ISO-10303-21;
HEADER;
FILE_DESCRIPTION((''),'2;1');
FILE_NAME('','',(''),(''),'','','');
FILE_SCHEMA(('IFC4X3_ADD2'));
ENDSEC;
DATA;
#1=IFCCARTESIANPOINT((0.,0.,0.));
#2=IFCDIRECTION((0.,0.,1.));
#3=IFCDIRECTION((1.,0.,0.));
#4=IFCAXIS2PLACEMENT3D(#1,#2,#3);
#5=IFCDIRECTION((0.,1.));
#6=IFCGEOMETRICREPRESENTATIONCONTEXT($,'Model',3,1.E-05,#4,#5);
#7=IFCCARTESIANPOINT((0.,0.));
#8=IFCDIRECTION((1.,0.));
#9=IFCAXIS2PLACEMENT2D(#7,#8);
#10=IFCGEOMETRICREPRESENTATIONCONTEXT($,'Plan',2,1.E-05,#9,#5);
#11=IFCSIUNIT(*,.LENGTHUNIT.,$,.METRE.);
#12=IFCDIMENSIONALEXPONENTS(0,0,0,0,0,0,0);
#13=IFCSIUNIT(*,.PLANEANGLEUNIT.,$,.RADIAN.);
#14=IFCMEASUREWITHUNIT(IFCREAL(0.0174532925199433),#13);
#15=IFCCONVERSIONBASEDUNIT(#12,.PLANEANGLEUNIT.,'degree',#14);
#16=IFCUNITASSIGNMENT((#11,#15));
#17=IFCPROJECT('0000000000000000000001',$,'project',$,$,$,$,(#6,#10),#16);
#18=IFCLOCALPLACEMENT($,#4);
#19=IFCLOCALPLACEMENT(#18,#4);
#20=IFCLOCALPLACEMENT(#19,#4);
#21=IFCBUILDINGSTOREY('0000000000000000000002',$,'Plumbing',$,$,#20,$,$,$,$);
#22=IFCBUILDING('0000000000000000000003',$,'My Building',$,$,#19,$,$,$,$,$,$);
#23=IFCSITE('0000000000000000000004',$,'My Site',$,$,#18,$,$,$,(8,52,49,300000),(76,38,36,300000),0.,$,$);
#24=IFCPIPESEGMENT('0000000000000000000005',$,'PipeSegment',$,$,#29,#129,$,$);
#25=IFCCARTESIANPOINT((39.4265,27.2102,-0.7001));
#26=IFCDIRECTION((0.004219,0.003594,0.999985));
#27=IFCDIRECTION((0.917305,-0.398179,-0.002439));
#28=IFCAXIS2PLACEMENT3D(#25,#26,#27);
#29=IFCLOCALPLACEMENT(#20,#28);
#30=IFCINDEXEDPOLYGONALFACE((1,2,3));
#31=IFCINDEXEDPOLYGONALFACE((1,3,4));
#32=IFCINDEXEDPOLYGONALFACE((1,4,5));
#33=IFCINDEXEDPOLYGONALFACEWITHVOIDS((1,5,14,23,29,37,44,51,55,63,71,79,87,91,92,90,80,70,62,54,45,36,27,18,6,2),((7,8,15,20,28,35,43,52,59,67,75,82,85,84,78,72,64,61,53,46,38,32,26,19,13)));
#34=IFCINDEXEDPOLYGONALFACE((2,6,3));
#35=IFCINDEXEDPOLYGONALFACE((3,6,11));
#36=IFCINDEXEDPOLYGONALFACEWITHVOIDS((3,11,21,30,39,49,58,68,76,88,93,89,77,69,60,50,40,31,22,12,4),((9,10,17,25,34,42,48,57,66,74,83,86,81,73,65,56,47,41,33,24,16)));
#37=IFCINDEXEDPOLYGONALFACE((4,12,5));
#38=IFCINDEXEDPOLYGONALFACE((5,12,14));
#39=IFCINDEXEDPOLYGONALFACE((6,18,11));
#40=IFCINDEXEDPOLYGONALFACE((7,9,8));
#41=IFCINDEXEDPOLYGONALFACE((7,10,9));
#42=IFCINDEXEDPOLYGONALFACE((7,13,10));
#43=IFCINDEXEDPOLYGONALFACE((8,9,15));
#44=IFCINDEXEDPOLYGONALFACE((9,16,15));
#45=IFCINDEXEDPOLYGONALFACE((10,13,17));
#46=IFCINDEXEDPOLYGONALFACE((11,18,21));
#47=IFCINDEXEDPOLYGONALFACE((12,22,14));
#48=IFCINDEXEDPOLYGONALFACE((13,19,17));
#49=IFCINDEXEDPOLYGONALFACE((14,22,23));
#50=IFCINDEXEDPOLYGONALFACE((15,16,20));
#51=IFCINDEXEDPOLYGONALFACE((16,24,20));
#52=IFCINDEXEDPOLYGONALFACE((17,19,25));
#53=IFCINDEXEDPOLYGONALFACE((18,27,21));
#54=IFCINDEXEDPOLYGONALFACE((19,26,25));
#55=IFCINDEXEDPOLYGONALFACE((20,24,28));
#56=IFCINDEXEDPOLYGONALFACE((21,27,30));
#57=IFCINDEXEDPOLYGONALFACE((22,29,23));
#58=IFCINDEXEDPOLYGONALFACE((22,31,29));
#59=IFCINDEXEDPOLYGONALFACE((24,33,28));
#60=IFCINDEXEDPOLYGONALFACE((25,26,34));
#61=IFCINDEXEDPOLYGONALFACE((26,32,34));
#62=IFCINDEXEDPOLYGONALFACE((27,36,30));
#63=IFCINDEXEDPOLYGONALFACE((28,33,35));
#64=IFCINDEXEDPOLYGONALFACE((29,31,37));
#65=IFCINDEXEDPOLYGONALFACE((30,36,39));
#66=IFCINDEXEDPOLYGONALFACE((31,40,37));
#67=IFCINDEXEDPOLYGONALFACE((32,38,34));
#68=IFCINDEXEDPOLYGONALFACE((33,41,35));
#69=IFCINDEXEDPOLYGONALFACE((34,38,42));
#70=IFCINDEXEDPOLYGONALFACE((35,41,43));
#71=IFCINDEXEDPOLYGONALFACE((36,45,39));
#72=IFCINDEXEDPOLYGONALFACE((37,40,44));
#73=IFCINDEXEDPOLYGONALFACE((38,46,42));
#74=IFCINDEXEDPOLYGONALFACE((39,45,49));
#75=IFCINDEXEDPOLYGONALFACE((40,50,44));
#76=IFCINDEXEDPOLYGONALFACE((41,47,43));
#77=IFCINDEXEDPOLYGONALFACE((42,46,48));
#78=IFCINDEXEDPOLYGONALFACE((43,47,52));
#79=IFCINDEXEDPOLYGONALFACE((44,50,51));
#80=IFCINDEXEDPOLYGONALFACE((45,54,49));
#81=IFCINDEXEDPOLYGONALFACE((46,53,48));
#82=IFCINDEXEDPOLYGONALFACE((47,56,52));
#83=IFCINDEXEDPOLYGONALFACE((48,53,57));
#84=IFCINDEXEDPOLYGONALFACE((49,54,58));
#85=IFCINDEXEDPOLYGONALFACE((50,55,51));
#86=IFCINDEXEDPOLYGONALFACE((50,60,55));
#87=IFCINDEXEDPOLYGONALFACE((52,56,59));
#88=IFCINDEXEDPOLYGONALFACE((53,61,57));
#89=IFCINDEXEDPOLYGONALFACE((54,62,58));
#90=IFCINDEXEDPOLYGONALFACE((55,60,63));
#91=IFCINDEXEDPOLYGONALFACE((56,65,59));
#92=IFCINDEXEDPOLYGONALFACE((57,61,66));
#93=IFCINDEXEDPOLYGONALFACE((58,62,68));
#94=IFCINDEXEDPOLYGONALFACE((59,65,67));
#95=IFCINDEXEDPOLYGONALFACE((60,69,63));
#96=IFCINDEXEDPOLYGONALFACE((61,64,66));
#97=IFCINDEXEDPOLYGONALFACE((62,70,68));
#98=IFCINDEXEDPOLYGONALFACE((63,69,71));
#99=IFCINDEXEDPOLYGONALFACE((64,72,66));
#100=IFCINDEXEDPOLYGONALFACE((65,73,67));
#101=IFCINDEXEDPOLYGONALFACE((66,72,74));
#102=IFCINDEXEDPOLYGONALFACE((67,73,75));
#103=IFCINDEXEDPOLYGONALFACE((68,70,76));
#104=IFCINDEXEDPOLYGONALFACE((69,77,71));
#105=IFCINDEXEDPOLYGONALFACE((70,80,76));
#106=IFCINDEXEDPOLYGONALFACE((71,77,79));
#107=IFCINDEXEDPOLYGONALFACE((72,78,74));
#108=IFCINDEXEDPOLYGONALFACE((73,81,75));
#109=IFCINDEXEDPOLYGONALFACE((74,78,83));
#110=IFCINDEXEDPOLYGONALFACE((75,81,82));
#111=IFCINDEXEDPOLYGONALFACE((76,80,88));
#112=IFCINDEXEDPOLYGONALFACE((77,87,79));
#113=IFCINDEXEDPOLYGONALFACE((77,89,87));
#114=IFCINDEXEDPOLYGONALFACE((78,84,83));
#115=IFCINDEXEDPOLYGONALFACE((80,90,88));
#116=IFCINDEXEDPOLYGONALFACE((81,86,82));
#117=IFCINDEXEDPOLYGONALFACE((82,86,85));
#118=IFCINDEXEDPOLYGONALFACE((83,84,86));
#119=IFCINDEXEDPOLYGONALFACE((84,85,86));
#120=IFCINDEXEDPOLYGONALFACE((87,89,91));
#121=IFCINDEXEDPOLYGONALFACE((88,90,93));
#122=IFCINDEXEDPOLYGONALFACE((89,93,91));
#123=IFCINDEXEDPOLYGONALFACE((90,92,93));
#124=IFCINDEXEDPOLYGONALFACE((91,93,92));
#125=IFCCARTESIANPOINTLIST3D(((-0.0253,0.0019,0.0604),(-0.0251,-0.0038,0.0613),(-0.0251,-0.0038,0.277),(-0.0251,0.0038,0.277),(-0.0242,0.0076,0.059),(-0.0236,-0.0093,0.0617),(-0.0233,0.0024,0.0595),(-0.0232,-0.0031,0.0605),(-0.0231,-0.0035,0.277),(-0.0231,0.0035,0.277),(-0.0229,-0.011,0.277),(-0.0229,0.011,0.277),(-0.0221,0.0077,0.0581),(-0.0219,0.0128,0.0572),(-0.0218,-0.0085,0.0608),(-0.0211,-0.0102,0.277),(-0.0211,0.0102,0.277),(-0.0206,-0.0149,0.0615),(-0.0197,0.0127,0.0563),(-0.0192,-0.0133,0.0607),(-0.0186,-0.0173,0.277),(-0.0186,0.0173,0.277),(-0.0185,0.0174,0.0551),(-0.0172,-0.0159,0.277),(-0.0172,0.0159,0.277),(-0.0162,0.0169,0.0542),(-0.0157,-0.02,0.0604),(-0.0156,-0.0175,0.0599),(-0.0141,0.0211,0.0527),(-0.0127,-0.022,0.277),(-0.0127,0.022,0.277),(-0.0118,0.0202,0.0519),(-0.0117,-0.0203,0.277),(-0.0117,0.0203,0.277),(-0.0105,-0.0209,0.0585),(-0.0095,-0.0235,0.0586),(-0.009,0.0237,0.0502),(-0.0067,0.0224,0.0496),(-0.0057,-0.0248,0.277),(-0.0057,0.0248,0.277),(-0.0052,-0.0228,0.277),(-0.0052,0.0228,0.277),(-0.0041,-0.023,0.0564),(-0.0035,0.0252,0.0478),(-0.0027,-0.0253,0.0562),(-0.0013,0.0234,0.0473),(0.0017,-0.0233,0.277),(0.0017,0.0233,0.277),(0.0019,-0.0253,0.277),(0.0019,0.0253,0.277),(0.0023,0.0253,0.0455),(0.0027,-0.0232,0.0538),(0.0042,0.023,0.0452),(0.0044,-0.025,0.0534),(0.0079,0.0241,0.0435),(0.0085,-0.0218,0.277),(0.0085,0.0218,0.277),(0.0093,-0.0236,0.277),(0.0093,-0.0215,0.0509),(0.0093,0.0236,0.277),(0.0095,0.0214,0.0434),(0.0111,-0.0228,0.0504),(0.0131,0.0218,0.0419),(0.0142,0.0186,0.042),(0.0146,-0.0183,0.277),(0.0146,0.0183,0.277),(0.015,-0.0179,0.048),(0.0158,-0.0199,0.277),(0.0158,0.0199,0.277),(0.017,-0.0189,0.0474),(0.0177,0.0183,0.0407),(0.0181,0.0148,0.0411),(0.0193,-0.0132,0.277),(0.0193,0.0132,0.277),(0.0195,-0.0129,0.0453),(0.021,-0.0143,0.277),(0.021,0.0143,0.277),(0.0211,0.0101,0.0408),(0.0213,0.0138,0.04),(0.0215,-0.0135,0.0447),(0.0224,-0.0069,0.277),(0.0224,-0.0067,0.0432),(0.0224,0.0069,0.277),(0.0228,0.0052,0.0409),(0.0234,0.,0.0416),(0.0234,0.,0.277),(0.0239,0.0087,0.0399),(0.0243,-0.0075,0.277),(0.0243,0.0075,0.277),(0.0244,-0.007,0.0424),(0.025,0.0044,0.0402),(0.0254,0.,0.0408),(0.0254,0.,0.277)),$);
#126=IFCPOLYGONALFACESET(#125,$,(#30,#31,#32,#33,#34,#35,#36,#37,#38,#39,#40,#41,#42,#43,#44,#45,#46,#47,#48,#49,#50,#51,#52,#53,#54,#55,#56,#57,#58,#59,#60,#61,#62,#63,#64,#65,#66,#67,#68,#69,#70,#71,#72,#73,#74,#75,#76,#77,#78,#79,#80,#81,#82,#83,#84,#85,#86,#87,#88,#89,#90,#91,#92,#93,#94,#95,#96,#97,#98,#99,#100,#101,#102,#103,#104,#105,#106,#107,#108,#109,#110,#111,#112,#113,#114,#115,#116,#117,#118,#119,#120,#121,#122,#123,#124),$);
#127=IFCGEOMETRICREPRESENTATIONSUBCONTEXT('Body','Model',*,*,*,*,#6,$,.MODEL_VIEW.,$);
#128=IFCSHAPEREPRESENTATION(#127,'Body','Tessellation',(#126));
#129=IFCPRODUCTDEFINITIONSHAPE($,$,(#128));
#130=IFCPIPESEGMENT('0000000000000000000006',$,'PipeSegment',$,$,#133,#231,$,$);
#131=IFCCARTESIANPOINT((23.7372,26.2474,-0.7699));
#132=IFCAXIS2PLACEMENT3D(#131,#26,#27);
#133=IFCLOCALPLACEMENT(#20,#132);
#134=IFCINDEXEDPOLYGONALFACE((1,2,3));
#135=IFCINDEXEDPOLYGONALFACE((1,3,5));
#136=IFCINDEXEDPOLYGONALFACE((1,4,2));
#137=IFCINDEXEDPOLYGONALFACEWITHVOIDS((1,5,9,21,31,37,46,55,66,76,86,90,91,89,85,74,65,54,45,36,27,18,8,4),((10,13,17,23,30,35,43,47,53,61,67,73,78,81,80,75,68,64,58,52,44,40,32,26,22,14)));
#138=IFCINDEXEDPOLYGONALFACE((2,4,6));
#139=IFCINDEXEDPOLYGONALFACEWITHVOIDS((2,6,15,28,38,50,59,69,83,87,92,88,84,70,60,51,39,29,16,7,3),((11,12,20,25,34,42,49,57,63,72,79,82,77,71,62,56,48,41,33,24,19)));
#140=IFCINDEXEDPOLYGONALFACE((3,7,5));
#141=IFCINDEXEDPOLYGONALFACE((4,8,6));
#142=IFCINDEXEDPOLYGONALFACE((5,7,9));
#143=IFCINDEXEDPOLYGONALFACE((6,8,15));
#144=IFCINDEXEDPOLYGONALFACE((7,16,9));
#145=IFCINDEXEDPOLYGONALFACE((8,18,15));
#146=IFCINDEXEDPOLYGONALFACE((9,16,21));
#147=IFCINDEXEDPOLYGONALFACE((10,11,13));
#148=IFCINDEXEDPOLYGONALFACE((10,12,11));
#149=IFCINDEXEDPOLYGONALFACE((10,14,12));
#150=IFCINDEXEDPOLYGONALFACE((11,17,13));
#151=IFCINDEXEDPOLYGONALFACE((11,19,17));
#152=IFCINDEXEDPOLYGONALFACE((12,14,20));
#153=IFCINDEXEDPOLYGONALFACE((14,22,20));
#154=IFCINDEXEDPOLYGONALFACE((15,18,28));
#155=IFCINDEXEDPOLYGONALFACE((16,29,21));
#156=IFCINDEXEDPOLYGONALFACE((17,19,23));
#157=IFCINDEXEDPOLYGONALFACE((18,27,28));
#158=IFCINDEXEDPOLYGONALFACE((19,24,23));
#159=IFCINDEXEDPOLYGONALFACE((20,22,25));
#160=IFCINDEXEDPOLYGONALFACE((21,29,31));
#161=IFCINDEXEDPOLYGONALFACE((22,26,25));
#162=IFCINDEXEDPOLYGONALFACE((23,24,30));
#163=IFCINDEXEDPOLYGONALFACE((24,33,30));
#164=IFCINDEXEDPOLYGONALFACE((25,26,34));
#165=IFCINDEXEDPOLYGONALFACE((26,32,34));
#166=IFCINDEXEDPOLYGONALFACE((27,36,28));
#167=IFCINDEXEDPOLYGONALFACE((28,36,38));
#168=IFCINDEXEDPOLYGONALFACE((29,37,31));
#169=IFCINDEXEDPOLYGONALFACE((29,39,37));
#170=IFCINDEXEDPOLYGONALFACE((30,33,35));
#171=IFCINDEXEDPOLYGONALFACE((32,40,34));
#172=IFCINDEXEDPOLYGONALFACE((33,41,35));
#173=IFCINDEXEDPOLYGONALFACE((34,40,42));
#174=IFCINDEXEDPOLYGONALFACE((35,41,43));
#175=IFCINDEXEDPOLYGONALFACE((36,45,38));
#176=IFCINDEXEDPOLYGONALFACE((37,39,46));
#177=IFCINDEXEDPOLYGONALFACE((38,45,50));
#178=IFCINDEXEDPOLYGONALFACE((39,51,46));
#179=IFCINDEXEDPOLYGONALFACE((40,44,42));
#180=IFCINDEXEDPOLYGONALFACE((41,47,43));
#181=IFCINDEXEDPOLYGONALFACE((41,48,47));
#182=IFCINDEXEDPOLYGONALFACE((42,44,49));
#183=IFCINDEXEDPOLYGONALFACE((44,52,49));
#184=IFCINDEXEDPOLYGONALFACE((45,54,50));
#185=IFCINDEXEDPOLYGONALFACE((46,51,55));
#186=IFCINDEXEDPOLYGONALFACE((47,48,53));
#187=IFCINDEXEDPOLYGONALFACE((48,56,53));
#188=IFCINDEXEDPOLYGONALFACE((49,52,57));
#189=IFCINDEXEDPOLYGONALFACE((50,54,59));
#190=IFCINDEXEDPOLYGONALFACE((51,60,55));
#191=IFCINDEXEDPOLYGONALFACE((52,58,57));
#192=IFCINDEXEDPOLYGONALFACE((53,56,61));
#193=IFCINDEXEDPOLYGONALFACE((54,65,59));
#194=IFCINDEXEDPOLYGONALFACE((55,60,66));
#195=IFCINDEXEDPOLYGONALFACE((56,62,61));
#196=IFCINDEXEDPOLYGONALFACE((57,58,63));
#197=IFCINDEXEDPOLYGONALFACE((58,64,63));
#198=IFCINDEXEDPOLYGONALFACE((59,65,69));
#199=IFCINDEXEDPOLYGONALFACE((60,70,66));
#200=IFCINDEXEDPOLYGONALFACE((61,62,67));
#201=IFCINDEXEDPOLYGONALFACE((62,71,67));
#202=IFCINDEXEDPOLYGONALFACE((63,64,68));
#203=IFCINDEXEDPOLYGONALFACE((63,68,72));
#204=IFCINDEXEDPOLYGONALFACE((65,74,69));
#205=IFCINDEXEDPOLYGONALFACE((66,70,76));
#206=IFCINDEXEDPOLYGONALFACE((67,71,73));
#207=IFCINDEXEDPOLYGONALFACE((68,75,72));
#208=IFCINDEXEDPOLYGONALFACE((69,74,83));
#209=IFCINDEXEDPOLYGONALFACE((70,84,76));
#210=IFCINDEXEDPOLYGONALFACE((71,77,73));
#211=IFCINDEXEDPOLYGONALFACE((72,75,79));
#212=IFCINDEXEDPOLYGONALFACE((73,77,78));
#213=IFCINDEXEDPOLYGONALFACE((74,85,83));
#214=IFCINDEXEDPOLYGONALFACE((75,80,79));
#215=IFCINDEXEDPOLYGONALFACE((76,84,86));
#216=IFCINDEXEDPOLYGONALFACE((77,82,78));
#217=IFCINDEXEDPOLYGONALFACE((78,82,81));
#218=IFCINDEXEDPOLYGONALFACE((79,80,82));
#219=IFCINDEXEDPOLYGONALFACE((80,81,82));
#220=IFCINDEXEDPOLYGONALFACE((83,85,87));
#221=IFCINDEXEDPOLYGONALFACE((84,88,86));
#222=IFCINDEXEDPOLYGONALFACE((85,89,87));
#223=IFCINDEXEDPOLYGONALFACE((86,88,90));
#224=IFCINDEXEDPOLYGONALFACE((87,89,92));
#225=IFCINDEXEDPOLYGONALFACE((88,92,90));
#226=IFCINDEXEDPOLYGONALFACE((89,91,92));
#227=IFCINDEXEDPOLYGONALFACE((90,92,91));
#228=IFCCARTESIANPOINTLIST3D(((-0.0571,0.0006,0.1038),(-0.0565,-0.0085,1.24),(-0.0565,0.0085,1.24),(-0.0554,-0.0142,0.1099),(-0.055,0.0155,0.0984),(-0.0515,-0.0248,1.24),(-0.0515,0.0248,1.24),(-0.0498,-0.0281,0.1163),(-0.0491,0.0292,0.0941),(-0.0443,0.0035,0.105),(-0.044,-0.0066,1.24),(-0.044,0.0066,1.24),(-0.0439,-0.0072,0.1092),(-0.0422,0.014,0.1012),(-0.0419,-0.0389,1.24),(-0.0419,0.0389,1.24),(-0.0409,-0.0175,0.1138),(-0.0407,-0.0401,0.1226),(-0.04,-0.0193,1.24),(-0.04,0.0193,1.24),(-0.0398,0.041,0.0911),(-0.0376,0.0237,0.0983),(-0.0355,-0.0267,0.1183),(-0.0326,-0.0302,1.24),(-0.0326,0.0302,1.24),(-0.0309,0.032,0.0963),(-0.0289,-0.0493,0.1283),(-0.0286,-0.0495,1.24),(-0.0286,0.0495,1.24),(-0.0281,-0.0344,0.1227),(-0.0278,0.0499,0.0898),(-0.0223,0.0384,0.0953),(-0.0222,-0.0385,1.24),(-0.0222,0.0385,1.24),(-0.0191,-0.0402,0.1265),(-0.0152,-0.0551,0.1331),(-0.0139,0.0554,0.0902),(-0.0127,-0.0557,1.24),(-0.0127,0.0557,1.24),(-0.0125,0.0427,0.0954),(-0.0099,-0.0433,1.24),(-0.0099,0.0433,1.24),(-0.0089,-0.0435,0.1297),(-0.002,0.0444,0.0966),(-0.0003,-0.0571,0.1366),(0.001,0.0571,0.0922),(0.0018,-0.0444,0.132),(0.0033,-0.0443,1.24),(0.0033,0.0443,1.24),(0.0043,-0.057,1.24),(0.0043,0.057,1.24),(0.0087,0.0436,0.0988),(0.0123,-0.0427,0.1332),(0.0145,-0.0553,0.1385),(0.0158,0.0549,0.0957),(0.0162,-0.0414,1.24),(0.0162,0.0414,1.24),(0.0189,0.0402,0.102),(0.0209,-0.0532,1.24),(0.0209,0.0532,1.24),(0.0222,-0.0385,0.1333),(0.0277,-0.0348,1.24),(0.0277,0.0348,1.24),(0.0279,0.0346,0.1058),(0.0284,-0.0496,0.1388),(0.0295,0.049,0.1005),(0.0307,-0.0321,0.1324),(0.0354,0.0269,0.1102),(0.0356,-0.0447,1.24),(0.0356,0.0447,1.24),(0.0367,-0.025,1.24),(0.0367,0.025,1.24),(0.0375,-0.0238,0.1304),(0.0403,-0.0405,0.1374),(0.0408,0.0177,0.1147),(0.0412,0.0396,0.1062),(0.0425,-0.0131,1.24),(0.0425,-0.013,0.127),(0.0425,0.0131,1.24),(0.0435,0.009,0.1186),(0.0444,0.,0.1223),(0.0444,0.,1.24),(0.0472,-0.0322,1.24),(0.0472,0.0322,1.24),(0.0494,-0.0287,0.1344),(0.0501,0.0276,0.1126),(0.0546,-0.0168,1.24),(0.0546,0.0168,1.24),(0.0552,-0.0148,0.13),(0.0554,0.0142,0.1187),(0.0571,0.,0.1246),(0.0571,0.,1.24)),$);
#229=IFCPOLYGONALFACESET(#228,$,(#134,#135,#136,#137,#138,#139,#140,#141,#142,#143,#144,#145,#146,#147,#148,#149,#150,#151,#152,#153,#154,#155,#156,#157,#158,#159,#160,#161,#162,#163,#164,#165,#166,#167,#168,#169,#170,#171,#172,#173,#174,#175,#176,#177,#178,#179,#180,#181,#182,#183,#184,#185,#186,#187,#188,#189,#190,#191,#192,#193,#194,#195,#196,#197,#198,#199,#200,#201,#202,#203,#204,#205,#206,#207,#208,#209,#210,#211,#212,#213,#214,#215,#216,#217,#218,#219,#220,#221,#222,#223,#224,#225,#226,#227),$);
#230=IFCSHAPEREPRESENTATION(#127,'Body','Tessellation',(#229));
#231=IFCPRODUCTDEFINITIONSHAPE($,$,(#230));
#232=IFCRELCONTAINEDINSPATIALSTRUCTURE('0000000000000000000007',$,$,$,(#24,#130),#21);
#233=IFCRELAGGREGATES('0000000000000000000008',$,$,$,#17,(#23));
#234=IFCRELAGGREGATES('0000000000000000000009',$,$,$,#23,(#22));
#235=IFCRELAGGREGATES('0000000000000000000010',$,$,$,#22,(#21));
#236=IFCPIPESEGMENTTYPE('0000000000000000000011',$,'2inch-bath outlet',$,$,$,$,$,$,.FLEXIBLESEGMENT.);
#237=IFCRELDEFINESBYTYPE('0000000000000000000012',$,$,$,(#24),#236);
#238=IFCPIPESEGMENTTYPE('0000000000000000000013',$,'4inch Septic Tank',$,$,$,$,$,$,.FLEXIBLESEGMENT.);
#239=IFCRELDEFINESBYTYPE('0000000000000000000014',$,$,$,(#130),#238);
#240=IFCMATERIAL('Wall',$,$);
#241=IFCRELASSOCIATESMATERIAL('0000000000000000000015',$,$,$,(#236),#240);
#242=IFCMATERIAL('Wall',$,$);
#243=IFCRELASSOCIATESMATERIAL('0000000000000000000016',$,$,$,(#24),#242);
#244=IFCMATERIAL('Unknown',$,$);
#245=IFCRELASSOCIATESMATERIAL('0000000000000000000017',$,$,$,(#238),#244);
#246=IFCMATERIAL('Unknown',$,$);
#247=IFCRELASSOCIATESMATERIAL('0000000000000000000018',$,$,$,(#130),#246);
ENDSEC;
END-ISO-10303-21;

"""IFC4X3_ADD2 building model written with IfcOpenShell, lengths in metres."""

from ifc_helpers import new_model, entity, si_unit, converted_unit, direction, frame, origin_with_axes, origin_2d_with_axis, place, context, subcontext, project, spatial, hollow_circle, extrude, clip, halfspace, material, material_profile, profile_set, profile_usage, type_object, element, save


model = new_model("IFC4X3_ADD2")

# Units and contexts
model_context = context("Model", 3, precision=1e-05, world=origin_with_axes(), true_north=direction((0.0, 1.0)))
plan_context = context("Plan", 2, precision=1e-05, world=origin_2d_with_axis(), true_north=direction((0.0, 1.0)))
body_context = subcontext(model_context, "Body", "Model", "MODEL_VIEW")
ifc_project = project(units=[si_unit("LENGTHUNIT", "METRE"), converted_unit("PLANEANGLEUNIT", "degree", entity("IfcReal", 0.0174532925199433), si_unit("PLANEANGLEUNIT", "RADIAN"), dimensions=[0, 0, 0, 0, 0, 0, 0])], contexts=[model_context, plan_context])

# Site, building, storey
site_placement = place(None, origin_with_axes())
site = spatial("IfcSite", under=ifc_project, at=site_placement, Name="My Site", RefLatitude=(8, 52, 49, 300000), RefLongitude=(76, 38, 36, 300000), RefElevation=0.0)
building_placement = place(site_placement, origin_with_axes())
building = spatial("IfcBuilding", under=site, at=building_placement, Name="My Building")
storey_placement = place(building_placement, origin_with_axes())
storey = spatial("IfcBuildingStorey", under=building, at=storey_placement, Name="Plumbing")

# Pipe segments
ifc_material_1 = material(Name="Wall")
ifc_material_profile_1 = material_profile(ifc_material_1, hollow_circle(Radius=0.0254, WallThickness=0.002))
ifc_profile_set_1 = profile_set([ifc_material_profile_1], Name="graywater")
ifc_material_2 = material(Name="Wall")
ifc_material_profile_2 = material_profile(ifc_material_2, hollow_circle(Radius=0.0254, WallThickness=0.002))
ifc_profile_set_2 = profile_set([ifc_material_profile_2], Name="graywater")
pipe_segment_type_1 = type_object("IfcPipeSegmentType", Name="2inch-bath outlet", PredefinedType="FLEXIBLESEGMENT", material=ifc_profile_set_2)
ifc_profile_usage_1 = profile_usage(ifc_profile_set_1, cardinal=5)
pipe_segment_1_placement = place(storey_placement, frame((39.4265, 27.2102, -0.7001), z_axis=(0.004219, 0.003594, 0.999985), x_axis=(0.917305, -0.398179, -0.002439)))
element("IfcPipeSegment", 1, at=pipe_segment_1_placement, inside=storey, type_object=pipe_segment_type_1, material=ifc_profile_usage_1, Name="PipeSegment", context=body_context, shape_type="Clipping", body=[
    clip(extrude(hollow_circle(Radius=0.0254, WallThickness=0.002), origin_with_axes(), (0.0, 0.0, 1.0), 0.277), halfspace(frame((-0.04, 0.0678, 0.0548), z_axis=(-0.361019, -0.158535, -0.918984), x_axis=(-0.402072, 0.915608, 0.0)), False)),
])
ifc_material_3 = material(Name="Unknown")
ifc_material_profile_3 = material_profile(ifc_material_3, hollow_circle(Radius=0.0571, WallThickness=0.0127))
ifc_profile_set_3 = profile_set([ifc_material_profile_3], Name="blackwater")
ifc_material_4 = material(Name="Unknown")
ifc_material_profile_4 = material_profile(ifc_material_4, hollow_circle(Radius=0.0571, WallThickness=0.0127))
ifc_profile_set_4 = profile_set([ifc_material_profile_4], Name="blackwater")
pipe_segment_type_2 = type_object("IfcPipeSegmentType", Name="4inch Septic Tank", PredefinedType="FLEXIBLESEGMENT", material=ifc_profile_set_4)
ifc_profile_usage_2 = profile_usage(ifc_profile_set_3, cardinal=5)
pipe_segment_2_placement = place(storey_placement, frame((23.7372, 26.2474, -0.7699), z_axis=(0.004219, 0.003594, 0.999985), x_axis=(0.917305, -0.398179, -0.002439)))
element("IfcPipeSegment", 2, at=pipe_segment_2_placement, inside=storey, type_object=pipe_segment_type_2, material=ifc_profile_usage_2, Name="PipeSegment", context=body_context, shape_type="Clipping", body=[
    clip(extrude(hollow_circle(Radius=0.0571, WallThickness=0.0127), origin_with_axes(), (0.0, 0.0, 1.0), 1.24), halfspace(frame((-0.1712, -0.0969, 0.1213), z_axis=(0.165343, -0.358689, -0.918697), x_axis=(-0.908157, -0.418629, 0.0)), False)),
])

save(model, "model.ifc")
